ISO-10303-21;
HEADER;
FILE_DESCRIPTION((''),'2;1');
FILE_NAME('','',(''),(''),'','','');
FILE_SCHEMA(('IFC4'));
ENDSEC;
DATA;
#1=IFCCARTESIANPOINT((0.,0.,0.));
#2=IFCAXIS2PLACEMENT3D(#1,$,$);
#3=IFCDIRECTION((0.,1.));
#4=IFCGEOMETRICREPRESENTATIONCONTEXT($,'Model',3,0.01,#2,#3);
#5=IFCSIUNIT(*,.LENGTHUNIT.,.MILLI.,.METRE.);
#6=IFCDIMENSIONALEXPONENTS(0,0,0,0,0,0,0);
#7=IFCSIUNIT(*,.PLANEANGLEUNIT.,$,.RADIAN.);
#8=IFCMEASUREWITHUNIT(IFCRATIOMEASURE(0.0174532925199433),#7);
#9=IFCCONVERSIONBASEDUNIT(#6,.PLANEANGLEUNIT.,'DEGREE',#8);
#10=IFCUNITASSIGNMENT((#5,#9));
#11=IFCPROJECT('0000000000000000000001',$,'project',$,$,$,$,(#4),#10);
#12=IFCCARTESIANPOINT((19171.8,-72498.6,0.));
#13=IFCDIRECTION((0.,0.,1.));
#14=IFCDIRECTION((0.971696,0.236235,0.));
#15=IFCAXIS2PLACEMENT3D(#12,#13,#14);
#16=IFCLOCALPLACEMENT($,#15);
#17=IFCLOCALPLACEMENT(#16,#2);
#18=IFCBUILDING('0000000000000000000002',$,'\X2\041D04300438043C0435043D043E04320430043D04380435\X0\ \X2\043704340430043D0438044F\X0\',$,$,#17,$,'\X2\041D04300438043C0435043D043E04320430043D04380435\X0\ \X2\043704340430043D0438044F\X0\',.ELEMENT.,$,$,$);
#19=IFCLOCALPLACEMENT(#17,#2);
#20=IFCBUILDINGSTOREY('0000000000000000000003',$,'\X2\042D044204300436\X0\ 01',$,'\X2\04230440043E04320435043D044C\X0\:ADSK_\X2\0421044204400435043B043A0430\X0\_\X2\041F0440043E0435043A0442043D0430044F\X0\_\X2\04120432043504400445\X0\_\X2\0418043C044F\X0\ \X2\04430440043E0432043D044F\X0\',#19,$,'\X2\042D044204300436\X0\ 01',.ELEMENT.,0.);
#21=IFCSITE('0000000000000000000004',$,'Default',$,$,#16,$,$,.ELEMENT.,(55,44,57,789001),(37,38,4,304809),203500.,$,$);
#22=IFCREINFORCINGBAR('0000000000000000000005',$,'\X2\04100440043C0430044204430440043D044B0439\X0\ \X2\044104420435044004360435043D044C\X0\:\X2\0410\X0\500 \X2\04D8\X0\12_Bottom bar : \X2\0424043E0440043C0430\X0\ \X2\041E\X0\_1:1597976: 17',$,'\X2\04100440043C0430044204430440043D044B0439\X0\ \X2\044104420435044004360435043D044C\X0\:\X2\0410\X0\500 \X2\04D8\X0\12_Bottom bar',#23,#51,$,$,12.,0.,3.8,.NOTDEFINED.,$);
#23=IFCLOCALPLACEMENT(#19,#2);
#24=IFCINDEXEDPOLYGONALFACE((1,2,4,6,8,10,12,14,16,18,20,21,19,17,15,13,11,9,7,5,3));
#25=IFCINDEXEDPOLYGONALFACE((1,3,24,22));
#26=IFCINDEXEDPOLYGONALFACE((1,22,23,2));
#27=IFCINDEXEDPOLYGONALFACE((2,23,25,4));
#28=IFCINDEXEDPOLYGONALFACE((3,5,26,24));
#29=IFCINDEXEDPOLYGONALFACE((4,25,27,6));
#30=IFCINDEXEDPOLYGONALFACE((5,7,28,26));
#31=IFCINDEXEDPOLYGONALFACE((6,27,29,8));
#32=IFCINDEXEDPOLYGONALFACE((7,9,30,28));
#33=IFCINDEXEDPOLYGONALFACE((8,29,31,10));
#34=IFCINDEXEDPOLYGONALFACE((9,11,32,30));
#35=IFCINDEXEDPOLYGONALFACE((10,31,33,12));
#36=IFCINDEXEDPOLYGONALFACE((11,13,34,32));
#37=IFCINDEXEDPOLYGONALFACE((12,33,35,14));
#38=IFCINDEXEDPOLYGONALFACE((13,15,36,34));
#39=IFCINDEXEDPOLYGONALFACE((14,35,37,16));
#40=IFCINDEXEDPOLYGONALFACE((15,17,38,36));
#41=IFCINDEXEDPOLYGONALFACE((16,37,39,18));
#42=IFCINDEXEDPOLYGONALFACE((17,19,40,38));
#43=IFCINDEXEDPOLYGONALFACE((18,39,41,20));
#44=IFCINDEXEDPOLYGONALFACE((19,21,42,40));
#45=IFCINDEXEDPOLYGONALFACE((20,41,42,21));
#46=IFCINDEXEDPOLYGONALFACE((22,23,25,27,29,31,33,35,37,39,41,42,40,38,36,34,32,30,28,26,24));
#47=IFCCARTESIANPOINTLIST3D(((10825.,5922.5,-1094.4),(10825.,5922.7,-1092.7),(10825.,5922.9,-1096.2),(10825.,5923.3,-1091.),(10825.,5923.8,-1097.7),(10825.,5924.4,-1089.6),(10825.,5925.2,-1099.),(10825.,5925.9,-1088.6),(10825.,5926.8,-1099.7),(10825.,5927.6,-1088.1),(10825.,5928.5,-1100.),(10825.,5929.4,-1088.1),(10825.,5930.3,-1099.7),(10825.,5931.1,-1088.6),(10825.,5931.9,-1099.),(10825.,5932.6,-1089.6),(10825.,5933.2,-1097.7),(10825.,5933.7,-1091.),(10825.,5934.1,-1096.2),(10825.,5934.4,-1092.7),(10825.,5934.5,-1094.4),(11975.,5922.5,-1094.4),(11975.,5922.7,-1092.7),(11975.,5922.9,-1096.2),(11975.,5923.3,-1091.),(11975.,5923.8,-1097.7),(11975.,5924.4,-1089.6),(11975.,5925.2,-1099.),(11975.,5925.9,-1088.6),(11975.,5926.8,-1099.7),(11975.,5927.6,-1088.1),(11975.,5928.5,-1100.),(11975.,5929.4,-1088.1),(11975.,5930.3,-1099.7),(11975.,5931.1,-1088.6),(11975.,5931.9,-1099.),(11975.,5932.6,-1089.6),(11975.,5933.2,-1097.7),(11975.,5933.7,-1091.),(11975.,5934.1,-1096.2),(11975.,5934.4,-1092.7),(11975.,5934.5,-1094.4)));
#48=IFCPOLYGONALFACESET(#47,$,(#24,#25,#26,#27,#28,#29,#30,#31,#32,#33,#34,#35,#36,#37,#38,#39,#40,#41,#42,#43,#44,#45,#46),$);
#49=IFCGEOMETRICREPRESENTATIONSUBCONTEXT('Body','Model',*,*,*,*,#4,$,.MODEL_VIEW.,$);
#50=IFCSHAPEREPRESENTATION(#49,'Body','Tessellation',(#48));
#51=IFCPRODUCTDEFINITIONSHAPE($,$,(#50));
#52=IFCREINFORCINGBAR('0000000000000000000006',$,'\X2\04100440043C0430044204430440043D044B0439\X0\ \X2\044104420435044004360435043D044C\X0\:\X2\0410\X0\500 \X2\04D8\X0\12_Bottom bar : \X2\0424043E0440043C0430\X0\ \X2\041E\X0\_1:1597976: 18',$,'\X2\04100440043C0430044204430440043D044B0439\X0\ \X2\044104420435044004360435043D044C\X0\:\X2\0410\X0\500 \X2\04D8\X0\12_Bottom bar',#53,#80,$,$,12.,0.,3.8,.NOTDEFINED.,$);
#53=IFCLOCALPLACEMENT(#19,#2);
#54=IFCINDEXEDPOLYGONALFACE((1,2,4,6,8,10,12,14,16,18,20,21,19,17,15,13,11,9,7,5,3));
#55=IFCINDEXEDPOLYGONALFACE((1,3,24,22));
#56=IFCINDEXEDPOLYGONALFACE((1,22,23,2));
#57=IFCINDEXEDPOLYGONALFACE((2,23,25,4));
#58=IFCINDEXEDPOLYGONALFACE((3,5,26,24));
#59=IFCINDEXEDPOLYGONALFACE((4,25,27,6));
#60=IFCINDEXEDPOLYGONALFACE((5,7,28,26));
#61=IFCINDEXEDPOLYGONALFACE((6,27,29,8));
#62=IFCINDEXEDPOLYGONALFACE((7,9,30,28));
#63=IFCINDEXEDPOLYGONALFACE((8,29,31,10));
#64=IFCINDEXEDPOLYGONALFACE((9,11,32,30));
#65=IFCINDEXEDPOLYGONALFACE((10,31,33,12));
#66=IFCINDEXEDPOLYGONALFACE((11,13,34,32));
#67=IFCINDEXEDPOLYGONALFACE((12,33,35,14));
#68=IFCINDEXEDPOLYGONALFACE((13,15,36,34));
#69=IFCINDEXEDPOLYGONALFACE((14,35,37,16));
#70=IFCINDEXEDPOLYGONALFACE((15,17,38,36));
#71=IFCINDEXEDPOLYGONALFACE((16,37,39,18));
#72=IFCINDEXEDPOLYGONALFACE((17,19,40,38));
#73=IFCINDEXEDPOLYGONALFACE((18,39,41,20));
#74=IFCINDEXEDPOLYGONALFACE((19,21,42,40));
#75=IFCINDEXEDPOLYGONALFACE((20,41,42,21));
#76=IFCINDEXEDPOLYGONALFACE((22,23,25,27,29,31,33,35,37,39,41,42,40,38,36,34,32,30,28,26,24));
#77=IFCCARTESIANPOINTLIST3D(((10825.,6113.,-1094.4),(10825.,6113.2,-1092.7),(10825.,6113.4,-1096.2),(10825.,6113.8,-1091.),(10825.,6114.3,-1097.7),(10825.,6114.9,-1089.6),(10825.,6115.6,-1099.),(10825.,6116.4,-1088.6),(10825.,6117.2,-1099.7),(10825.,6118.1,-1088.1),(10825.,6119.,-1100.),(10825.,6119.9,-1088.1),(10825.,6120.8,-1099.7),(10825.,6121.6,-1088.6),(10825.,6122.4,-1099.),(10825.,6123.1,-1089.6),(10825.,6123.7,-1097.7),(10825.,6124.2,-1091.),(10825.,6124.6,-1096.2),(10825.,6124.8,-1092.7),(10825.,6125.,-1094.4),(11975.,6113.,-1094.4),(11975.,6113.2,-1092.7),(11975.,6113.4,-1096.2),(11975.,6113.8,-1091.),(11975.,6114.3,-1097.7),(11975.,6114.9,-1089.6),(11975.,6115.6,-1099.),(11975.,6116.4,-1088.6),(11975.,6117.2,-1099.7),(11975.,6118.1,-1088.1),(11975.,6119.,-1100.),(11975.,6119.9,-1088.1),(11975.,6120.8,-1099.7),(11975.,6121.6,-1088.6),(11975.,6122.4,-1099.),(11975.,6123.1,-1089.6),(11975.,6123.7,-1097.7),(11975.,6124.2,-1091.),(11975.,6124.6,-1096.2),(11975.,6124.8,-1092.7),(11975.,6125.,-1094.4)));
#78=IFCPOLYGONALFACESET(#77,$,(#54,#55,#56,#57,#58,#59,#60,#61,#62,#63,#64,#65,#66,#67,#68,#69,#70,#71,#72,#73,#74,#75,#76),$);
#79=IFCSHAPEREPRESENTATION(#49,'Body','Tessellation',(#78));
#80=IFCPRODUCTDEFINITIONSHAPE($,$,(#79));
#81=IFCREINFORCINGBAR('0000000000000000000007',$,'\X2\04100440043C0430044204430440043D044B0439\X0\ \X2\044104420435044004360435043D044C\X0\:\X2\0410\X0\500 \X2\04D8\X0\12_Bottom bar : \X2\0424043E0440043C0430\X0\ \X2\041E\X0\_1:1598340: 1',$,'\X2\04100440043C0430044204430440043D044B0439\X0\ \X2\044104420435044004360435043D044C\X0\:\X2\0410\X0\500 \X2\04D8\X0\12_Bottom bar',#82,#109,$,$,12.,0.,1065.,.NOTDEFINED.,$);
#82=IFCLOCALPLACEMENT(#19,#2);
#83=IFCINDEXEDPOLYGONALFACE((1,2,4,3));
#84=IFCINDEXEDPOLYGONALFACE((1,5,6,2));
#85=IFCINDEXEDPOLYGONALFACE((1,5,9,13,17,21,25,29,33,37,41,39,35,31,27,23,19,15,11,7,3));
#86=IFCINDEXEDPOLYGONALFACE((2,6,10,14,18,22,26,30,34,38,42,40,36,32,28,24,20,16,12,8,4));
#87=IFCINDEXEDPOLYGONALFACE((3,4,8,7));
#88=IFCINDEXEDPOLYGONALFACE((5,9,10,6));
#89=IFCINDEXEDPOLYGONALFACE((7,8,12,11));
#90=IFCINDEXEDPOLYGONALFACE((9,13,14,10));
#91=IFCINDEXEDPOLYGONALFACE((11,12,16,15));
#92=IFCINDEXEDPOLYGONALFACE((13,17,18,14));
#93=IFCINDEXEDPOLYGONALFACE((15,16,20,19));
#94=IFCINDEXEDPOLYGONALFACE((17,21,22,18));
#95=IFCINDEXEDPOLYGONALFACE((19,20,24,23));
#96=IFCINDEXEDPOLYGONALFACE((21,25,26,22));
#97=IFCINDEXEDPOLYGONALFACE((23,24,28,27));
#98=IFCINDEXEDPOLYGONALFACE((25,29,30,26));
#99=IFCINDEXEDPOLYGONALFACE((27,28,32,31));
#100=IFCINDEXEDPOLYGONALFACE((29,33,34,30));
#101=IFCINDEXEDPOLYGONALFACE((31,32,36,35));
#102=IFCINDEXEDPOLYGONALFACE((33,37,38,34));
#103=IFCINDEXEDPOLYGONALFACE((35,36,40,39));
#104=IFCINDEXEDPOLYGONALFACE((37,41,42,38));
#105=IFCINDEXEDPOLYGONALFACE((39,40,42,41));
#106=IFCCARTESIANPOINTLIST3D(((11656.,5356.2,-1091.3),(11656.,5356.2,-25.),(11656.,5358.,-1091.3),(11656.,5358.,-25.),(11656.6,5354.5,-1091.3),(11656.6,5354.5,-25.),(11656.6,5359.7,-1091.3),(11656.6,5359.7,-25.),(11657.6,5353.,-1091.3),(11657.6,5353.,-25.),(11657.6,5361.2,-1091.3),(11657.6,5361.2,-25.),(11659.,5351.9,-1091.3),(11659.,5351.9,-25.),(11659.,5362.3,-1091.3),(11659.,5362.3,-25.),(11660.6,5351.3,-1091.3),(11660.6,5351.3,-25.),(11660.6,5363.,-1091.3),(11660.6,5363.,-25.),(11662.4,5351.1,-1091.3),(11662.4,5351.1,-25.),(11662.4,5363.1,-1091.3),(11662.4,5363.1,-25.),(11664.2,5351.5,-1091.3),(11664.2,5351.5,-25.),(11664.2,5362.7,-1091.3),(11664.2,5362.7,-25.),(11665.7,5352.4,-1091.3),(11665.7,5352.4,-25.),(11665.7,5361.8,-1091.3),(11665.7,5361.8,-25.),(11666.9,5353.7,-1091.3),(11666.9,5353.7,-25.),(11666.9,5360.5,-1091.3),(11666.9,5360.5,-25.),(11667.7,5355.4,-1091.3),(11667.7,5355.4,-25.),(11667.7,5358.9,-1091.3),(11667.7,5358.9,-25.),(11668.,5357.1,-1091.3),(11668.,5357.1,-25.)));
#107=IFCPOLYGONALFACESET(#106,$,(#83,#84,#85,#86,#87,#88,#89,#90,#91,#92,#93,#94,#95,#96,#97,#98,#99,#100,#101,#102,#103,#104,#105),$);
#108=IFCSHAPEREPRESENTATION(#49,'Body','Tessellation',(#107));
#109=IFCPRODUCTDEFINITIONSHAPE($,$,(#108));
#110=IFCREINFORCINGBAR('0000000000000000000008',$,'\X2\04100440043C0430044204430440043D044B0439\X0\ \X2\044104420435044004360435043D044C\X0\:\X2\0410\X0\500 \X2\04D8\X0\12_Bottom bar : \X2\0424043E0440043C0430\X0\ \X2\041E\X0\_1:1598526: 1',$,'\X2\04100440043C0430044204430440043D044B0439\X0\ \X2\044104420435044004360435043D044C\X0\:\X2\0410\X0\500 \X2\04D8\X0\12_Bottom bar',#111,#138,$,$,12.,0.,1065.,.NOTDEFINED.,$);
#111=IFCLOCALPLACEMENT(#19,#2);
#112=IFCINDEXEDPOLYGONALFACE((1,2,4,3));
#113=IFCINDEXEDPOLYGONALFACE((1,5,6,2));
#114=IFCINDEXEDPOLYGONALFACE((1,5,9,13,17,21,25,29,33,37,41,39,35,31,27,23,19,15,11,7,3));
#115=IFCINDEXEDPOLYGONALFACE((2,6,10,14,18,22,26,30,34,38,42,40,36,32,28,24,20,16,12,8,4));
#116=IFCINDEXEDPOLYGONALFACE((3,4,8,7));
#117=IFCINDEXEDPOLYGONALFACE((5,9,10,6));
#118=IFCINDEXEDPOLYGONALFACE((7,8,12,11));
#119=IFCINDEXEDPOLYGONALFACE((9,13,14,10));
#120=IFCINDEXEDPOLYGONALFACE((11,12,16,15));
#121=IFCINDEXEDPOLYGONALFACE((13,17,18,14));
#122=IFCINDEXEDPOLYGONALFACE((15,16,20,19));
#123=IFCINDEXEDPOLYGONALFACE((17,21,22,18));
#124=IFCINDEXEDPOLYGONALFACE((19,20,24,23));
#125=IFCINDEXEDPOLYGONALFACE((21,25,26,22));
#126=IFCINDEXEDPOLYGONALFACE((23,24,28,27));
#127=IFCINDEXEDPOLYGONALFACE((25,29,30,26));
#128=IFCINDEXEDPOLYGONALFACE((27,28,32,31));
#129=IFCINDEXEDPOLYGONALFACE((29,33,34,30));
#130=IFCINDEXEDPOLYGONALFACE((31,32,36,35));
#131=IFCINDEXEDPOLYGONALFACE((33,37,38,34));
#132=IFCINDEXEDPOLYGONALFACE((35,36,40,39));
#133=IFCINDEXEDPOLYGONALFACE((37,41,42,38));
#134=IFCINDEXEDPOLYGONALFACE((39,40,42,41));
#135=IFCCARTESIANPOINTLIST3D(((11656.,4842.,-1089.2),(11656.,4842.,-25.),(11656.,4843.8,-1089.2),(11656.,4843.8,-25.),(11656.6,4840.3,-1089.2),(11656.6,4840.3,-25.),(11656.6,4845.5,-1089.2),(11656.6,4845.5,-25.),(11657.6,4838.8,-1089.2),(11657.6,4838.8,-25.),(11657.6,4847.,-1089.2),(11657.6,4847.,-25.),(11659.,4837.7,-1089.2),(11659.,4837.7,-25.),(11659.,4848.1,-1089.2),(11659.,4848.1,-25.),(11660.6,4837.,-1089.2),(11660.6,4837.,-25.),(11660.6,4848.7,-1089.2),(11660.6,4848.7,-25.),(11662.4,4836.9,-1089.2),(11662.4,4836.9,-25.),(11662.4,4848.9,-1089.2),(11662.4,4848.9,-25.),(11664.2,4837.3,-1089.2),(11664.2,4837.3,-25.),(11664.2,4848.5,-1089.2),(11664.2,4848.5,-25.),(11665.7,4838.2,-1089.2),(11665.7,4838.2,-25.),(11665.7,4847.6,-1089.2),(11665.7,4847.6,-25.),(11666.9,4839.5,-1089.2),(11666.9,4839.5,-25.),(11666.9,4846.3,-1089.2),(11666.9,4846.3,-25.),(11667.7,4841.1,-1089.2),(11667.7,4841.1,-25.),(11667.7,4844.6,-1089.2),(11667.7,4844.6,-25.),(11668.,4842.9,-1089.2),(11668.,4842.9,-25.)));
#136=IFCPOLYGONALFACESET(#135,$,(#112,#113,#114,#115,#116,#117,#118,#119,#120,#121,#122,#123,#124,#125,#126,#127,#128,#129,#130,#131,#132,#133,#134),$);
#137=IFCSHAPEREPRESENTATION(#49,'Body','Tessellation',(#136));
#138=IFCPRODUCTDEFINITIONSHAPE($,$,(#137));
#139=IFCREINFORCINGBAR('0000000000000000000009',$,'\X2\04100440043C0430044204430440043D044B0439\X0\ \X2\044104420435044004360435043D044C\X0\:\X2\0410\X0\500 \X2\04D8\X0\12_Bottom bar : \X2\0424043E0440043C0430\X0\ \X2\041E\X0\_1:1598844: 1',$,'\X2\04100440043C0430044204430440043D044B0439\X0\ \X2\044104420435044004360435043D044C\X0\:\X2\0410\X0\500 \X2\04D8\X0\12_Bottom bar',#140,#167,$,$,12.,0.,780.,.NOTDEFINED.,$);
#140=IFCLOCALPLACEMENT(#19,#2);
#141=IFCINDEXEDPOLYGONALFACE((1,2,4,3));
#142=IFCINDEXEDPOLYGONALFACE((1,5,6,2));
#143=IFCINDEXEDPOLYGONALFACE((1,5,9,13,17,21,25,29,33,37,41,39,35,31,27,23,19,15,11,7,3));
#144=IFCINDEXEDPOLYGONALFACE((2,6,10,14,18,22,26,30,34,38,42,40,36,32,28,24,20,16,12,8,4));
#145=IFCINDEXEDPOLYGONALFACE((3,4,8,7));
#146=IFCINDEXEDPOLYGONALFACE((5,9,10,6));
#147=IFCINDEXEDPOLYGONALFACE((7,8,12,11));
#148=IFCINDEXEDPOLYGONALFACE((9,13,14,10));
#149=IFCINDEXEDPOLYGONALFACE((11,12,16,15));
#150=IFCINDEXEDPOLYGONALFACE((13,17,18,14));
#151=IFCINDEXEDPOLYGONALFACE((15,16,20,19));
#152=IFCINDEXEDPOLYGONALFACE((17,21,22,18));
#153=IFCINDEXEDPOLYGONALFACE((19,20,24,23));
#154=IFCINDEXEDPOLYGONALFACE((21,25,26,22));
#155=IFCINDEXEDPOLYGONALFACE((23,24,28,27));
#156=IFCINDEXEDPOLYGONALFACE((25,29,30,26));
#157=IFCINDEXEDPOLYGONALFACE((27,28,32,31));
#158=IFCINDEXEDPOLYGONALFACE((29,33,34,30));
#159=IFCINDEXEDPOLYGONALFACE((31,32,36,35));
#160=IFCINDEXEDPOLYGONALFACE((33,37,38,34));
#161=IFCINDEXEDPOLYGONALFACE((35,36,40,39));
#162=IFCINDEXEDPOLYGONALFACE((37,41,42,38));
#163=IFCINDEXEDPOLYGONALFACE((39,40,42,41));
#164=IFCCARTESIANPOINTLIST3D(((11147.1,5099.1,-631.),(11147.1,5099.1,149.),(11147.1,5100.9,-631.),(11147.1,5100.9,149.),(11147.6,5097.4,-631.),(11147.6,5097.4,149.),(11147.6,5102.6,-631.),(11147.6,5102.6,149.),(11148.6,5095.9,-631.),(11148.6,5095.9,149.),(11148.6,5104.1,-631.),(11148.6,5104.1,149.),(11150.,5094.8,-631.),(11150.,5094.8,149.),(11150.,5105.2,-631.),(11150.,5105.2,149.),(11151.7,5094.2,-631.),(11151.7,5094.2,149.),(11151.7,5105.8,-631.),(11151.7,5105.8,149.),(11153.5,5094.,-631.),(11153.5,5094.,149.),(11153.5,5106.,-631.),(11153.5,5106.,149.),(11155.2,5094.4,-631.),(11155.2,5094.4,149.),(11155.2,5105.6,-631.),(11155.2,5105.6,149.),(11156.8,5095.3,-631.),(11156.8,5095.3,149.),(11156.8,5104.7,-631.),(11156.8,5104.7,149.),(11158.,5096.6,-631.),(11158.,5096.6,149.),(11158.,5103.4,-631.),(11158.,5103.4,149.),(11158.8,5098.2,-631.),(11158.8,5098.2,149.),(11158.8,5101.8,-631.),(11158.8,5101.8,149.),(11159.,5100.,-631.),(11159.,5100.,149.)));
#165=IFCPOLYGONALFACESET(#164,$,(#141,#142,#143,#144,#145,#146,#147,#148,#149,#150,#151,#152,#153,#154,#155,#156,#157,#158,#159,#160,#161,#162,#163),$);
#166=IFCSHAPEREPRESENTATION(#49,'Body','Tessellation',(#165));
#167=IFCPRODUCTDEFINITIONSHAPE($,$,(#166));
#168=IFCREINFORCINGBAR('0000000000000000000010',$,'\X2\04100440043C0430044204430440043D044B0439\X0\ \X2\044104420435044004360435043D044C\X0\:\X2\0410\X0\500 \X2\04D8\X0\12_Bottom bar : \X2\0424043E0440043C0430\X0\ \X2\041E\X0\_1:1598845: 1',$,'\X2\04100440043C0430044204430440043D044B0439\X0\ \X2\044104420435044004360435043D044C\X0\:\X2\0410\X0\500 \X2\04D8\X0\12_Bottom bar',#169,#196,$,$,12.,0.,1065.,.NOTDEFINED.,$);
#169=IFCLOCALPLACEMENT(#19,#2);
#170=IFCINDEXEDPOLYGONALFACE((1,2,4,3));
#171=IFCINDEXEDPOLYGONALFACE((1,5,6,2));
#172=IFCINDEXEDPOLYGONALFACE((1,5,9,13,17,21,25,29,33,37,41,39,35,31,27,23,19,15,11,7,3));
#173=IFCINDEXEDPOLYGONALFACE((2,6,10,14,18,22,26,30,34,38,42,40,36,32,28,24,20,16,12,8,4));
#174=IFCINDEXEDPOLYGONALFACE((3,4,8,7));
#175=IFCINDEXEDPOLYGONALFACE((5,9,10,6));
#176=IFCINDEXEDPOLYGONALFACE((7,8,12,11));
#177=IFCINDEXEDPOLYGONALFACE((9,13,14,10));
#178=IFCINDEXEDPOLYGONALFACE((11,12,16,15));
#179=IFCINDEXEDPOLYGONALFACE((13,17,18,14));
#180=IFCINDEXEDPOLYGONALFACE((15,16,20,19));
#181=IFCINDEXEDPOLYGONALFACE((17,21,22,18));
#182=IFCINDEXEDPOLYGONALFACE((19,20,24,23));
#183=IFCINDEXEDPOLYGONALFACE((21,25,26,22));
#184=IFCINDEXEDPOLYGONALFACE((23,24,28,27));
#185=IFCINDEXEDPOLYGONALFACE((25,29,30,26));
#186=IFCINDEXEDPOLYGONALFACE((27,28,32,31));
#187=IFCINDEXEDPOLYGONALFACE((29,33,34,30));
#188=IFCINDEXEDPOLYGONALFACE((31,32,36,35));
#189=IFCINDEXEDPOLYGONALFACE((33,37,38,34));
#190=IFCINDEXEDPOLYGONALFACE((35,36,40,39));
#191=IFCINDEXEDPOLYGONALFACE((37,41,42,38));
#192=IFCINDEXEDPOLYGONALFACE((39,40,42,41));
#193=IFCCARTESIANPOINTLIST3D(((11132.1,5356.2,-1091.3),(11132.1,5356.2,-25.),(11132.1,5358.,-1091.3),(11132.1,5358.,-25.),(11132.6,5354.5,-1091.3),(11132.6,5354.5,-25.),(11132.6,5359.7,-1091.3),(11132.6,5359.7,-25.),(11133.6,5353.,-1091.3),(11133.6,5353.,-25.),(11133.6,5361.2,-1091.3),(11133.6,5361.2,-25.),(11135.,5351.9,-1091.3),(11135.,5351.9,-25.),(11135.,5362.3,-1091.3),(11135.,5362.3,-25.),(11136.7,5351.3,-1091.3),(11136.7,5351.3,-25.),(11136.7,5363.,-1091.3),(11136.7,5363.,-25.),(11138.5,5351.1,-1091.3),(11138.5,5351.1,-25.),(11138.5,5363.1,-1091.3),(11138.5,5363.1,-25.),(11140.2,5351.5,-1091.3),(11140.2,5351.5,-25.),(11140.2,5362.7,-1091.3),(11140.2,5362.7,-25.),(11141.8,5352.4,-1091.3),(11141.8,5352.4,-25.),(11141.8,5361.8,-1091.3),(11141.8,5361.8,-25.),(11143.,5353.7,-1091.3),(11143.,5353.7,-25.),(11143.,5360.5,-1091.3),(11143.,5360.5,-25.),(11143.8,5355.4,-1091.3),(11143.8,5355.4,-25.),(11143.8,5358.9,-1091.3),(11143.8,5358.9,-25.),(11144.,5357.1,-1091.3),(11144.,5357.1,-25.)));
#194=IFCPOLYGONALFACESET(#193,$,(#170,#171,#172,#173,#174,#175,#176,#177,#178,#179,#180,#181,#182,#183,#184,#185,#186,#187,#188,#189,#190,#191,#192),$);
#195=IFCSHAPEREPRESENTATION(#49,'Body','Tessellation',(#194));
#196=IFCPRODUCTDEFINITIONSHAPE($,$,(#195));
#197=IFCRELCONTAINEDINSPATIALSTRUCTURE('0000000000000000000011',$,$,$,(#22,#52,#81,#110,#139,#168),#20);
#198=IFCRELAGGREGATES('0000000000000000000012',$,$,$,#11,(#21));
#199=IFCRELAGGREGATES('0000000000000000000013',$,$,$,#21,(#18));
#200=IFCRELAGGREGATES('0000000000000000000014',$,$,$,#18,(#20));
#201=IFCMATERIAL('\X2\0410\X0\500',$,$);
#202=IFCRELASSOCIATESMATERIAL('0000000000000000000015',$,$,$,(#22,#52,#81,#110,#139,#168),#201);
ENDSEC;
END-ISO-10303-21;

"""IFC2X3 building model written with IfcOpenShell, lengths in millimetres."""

from ifc_helpers import new_model, entity, si_unit, converted_unit, direction, frame, origin, place, context, subcontext, project, spatial, material, element, save


model = new_model("IFC2X3")

# Units and contexts
model_context = context("Model", 3, precision=0.01, world=origin(), true_north=direction((0.0, 1.0)))
body_context = subcontext(model_context, "Body", "Model", "MODEL_VIEW")
ifc_project = project(units=[si_unit("LENGTHUNIT", "METRE", prefix="MILLI"), converted_unit("PLANEANGLEUNIT", "DEGREE", entity("IfcRatioMeasure", 0.0174532925199433), si_unit("PLANEANGLEUNIT", "RADIAN"), dimensions=[0, 0, 0, 0, 0, 0, 0])], contexts=[model_context])

# Site, building, storey
site_placement = place(None, frame((19171.8, -72498.6, 0.0), z_axis=(0.0, 0.0, 1.0), x_axis=(0.971696, 0.236235, 0.0)))
site = spatial("IfcSite", under=ifc_project, at=site_placement, Name="Default", CompositionType="ELEMENT", RefLatitude=(55, 44, 57, 789001), RefLongitude=(37, 38, 4, 304809), RefElevation=203500.0)
building_placement = place(site_placement, origin())
building = spatial("IfcBuilding", under=site, at=building_placement, Name="Наименование здания", LongName="Наименование здания", CompositionType="ELEMENT")
storey_placement = place(building_placement, origin())
storey = spatial("IfcBuildingStorey", under=building, at=storey_placement, Name="Этаж 01", ObjectType="Уровень:ADSK_Стрелка_Проектная_Вверх_Имя уровня", LongName="Этаж 01", CompositionType="ELEMENT", Elevation=0.0)

# Reinforcing bars
ifc_material = material(Name="А500")
placement = place(storey_placement, origin())
element("IfcReinforcingBar", 1, at=placement, inside=storey, material=ifc_material, Name="Арматурный стержень:А500 Ә12_Bottom bar : Форма О_1:1597976: 17", ObjectType="Арматурный стержень:А500 Ә12_Bottom bar", BarLength=3.8, BarRole="NOTDEFINED", CrossSectionArea=0.0, NominalDiameter=12.0, context=body_context, shape_type="AdvancedSweptSolid", body=[
    entity("IfcSweptDiskSolid", entity("IfcCompositeCurve", [entity("IfcCompositeCurveSegment", "CONTINUOUS", True, entity("IfcPolyline", [entity("IfcCartesianPoint", [11975.0, 5928.5, -1094.0]), entity("IfcCartesianPoint", [10825.0, 5928.5, -1094.0])]))], False), 6.0, None, 0.0, 1.0),
])
element("IfcReinforcingBar", 2, at=placement, inside=storey, material=ifc_material, Name="Арматурный стержень:А500 Ә12_Bottom bar : Форма О_1:1597976: 18", ObjectType="Арматурный стержень:А500 Ә12_Bottom bar", BarLength=3.8, BarRole="NOTDEFINED", CrossSectionArea=0.0, NominalDiameter=12.0, context=body_context, shape_type="AdvancedSweptSolid", body=[
    entity("IfcSweptDiskSolid", entity("IfcCompositeCurve", [entity("IfcCompositeCurveSegment", "CONTINUOUS", True, entity("IfcPolyline", [entity("IfcCartesianPoint", [11975.0, 6119.0, -1094.0]), entity("IfcCartesianPoint", [10825.0, 6119.0, -1094.0])]))], False), 6.0, None, 0.0, 1.0),
])
element("IfcReinforcingBar", 3, at=placement, inside=storey, material=ifc_material, Name="Арматурный стержень:А500 Ә12_Bottom bar : Форма О_1:1598340: 1", ObjectType="Арматурный стержень:А500 Ә12_Bottom bar", BarLength=1065.0, BarRole="NOTDEFINED", CrossSectionArea=0.0, NominalDiameter=12.0, context=body_context, shape_type="AdvancedSweptSolid", body=[
    entity("IfcSweptDiskSolid", entity("IfcCompositeCurve", [entity("IfcCompositeCurveSegment", "CONTINUOUS", True, entity("IfcPolyline", [entity("IfcCartesianPoint", [11662.0, 5357.1, -1091.3]), entity("IfcCartesianPoint", [11662.0, 5357.1, -25.0])]))], False), 6.0, None, 0.0, 1.0),
])
element("IfcReinforcingBar", 4, at=placement, inside=storey, material=ifc_material, Name="Арматурный стержень:А500 Ә12_Bottom bar : Форма О_1:1598526: 1", ObjectType="Арматурный стержень:А500 Ә12_Bottom bar", BarLength=1065.0, BarRole="NOTDEFINED", CrossSectionArea=0.0, NominalDiameter=12.0, context=body_context, shape_type="AdvancedSweptSolid", body=[
    entity("IfcSweptDiskSolid", entity("IfcCompositeCurve", [entity("IfcCompositeCurveSegment", "CONTINUOUS", True, entity("IfcPolyline", [entity("IfcCartesianPoint", [11662.0, 4842.9, -1089.2]), entity("IfcCartesianPoint", [11662.0, 4842.9, -25.0])]))], False), 6.0, None, 0.0, 1.0),
])
element("IfcReinforcingBar", 5, at=placement, inside=storey, material=ifc_material, Name="Арматурный стержень:А500 Ә12_Bottom bar : Форма О_1:1598844: 1", ObjectType="Арматурный стержень:А500 Ә12_Bottom bar", BarLength=780.0, BarRole="NOTDEFINED", CrossSectionArea=0.0, NominalDiameter=12.0, context=body_context, shape_type="AdvancedSweptSolid", body=[
    entity("IfcSweptDiskSolid", entity("IfcCompositeCurve", [entity("IfcCompositeCurveSegment", "CONTINUOUS", True, entity("IfcPolyline", [entity("IfcCartesianPoint", [11153.0, 5100.0, -631.0]), entity("IfcCartesianPoint", [11153.0, 5100.0, 149.0])]))], False), 6.0, None, 0.0, 1.0),
])
element("IfcReinforcingBar", 6, at=placement, inside=storey, material=ifc_material, Name="Арматурный стержень:А500 Ә12_Bottom bar : Форма О_1:1598845: 1", ObjectType="Арматурный стержень:А500 Ә12_Bottom bar", BarLength=1065.0, BarRole="NOTDEFINED", CrossSectionArea=0.0, NominalDiameter=12.0, context=body_context, shape_type="AdvancedSweptSolid", body=[
    entity("IfcSweptDiskSolid", entity("IfcCompositeCurve", [entity("IfcCompositeCurveSegment", "CONTINUOUS", True, entity("IfcPolyline", [entity("IfcCartesianPoint", [11138.0, 5357.1, -1091.3]), entity("IfcCartesianPoint", [11138.0, 5357.1, -25.0])]))], False), 6.0, None, 0.0, 1.0),
])

save(model, "model.ifc")
